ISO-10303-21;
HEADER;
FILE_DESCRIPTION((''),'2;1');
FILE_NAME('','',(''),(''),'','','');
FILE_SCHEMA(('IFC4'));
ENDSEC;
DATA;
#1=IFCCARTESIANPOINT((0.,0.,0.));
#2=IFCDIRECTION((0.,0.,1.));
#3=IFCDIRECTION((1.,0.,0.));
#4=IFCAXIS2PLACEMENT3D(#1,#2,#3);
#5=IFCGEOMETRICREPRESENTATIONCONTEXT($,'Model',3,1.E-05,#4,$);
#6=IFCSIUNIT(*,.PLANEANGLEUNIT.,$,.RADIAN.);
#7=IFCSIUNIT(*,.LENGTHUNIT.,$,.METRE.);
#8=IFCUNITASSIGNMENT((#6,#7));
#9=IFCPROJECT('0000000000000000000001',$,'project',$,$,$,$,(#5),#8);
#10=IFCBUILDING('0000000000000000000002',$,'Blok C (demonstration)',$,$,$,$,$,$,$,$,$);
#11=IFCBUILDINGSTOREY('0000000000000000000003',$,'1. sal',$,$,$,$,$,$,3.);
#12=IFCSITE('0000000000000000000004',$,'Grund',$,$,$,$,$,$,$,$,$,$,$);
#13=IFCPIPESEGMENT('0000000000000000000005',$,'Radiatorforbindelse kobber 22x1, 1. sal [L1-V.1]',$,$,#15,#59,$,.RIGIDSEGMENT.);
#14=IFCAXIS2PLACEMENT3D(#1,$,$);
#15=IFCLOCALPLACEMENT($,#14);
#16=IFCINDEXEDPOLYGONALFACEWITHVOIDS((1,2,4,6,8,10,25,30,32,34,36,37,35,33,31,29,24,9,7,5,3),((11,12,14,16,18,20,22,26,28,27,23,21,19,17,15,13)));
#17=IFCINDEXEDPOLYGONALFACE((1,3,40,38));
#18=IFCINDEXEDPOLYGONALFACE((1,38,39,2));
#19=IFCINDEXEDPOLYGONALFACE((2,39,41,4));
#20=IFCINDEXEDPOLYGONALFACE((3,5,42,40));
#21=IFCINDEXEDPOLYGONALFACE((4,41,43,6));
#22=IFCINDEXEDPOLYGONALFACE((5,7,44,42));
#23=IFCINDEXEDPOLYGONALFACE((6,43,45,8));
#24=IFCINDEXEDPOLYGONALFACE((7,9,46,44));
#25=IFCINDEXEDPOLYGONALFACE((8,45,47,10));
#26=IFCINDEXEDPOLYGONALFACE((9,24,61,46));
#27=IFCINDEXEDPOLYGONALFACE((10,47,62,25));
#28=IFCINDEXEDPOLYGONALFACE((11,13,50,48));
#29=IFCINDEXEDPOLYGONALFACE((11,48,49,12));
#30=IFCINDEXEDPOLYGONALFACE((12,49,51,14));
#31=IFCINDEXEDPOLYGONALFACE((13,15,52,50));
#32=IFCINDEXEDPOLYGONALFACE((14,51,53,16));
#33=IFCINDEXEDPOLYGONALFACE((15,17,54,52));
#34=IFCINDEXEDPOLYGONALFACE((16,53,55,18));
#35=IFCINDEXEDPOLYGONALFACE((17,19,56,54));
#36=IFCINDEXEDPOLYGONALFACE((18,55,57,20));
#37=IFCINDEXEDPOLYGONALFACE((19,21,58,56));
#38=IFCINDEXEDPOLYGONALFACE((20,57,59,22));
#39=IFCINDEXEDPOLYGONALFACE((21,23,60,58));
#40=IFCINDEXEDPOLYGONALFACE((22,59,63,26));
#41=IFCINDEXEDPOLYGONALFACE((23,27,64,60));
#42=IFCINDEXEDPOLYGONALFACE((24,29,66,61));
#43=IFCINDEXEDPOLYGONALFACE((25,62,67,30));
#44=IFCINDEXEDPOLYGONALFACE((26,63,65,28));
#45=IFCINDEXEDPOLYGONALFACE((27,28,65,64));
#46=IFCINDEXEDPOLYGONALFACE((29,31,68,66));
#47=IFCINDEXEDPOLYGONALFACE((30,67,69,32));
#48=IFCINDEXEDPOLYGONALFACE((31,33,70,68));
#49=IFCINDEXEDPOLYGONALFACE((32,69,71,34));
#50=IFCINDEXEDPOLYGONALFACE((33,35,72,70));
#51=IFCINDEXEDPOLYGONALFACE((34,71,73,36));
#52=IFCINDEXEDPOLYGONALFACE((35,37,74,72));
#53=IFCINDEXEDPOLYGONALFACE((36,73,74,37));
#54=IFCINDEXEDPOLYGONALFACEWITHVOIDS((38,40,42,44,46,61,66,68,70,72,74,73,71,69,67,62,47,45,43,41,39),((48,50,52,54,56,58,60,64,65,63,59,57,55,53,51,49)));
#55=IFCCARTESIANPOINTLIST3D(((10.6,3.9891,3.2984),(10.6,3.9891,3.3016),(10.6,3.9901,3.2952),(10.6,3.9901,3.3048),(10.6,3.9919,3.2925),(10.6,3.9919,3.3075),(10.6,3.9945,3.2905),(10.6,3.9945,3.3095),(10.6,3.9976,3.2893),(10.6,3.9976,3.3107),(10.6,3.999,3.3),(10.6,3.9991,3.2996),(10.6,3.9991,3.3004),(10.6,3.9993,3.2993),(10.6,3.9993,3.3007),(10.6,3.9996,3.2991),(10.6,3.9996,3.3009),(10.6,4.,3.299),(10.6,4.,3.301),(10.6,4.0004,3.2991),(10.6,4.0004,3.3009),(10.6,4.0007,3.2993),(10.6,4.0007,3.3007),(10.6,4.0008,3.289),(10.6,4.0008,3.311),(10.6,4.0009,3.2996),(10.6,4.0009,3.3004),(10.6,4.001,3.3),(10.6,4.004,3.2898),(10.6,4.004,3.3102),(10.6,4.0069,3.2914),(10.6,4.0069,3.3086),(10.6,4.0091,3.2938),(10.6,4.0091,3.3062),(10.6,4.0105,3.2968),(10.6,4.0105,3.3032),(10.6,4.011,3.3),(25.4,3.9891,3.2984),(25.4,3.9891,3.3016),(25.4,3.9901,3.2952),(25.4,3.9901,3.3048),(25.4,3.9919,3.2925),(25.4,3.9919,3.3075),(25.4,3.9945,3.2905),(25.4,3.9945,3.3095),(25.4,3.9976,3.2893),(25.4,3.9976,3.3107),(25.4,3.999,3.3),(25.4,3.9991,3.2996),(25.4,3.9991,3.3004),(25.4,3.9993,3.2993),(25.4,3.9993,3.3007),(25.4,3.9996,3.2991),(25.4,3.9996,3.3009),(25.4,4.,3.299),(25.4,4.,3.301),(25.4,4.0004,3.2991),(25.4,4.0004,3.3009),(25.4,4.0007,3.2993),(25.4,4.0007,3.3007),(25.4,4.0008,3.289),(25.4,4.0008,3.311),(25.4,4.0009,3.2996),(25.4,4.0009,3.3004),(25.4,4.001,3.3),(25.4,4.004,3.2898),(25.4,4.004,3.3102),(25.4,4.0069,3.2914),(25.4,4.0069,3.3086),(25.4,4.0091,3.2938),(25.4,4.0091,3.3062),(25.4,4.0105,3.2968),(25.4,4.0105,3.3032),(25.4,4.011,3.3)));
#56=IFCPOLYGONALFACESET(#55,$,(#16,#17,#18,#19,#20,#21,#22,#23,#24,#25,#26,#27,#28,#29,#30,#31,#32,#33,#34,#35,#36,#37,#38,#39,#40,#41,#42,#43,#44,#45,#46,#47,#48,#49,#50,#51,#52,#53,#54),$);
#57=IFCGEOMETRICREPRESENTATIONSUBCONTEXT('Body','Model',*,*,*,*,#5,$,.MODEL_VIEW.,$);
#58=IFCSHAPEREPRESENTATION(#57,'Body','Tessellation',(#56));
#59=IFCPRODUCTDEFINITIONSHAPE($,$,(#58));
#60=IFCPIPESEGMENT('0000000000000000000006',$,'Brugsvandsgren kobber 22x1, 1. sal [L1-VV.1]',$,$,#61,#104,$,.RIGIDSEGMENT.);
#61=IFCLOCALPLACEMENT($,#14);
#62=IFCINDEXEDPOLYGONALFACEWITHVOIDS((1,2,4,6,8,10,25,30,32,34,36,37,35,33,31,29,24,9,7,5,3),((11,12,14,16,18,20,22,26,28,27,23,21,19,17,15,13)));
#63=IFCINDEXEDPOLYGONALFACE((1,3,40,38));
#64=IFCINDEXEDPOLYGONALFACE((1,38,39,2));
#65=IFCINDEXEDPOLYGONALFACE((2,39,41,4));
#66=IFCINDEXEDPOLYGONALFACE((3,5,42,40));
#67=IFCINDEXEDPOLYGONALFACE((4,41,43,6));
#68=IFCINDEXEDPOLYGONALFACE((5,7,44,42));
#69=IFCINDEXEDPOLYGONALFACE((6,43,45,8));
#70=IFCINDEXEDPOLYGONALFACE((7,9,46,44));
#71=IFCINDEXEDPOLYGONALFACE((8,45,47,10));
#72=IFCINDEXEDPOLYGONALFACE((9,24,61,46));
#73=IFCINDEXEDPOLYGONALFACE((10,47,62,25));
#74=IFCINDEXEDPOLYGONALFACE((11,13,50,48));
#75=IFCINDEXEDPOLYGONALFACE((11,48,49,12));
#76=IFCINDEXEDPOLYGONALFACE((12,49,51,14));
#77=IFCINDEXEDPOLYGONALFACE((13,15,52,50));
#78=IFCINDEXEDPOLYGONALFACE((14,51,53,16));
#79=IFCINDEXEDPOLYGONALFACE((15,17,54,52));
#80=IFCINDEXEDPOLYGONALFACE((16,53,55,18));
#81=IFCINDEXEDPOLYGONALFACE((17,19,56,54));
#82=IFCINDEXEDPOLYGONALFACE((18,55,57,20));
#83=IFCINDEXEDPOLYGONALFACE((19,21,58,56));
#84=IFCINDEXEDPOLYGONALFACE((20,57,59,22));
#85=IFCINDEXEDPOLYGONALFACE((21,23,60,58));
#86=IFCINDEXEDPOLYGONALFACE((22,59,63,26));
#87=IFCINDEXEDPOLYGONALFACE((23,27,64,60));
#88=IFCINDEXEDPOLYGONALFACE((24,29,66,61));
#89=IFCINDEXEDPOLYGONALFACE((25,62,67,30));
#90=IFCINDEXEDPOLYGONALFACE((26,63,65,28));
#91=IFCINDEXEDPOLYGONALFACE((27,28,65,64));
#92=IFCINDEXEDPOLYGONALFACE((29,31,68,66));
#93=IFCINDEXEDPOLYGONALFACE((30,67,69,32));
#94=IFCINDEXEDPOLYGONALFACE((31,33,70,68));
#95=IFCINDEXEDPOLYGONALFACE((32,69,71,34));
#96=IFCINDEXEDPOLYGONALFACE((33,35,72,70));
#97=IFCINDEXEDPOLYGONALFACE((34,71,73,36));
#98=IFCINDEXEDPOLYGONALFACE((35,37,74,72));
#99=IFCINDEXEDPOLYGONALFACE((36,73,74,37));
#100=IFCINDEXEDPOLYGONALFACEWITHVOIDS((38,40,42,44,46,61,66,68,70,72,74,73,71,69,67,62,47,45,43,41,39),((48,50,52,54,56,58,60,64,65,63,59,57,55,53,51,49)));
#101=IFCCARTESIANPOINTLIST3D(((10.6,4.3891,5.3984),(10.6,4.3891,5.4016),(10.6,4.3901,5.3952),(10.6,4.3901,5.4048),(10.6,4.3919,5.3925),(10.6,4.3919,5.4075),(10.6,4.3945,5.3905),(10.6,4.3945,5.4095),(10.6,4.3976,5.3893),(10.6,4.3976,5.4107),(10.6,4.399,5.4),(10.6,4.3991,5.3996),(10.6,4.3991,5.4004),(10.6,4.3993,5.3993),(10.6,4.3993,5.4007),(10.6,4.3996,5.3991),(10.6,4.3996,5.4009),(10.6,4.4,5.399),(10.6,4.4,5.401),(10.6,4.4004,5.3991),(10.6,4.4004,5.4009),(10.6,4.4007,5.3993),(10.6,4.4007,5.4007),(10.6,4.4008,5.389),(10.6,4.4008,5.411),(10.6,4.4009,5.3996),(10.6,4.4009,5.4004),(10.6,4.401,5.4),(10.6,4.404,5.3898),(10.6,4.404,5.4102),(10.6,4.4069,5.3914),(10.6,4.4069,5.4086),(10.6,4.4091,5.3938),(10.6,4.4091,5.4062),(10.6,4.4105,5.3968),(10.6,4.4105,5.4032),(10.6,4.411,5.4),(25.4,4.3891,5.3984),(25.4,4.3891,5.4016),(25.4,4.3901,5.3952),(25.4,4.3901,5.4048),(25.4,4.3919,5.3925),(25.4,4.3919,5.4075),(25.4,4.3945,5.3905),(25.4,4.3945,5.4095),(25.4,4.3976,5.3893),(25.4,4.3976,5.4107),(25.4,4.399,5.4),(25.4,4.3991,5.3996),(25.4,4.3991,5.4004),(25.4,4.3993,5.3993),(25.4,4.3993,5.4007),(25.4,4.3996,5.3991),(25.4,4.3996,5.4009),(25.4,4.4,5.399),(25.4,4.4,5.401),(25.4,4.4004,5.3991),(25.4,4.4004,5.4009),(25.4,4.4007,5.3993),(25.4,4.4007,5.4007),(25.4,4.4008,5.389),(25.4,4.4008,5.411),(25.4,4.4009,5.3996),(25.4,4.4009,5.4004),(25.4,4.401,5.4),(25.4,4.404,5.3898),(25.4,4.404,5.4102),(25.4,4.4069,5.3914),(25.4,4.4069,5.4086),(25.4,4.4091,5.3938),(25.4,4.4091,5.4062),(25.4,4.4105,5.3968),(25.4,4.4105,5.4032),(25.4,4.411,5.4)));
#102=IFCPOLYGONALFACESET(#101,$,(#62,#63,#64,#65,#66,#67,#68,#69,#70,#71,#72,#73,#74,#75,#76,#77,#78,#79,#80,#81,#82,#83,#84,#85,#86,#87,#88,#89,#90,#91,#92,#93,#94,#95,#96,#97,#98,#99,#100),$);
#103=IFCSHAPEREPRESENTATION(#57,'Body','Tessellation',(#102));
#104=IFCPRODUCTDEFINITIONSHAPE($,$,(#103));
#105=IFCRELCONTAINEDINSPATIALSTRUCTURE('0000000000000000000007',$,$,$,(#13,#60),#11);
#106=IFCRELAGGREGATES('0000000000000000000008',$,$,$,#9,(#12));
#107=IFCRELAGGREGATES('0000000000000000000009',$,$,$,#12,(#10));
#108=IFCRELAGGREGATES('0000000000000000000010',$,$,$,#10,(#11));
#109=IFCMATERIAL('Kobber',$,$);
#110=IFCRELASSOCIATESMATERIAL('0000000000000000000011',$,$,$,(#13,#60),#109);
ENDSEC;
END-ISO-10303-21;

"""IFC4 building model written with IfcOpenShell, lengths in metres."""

from ifc_helpers import new_model, si_unit, frame, origin_with_axes, place, context, subcontext, project, spatial, hollow_circle, extrude, material, element, save


model = new_model("IFC4")

# Units and contexts
model_context = context("Model", 3, precision=1e-05, world=origin_with_axes())
body_context = subcontext(model_context, "Body", "Model", "MODEL_VIEW")
ifc_project = project(units=[si_unit("PLANEANGLEUNIT", "RADIAN"), si_unit("LENGTHUNIT", "METRE")], contexts=[model_context])

# Site, building, storey
site = spatial("IfcSite", under=ifc_project, Name="Grund")
building = spatial("IfcBuilding", under=site, Name="Blok C (demonstration)")
storey = spatial("IfcBuildingStorey", under=building, Name="1. sal", Elevation=3.0)

# Pipe segments
ifc_material_1 = material(Name="Kobber")
pipe_segment_1_placement = place(None, origin_with_axes())
element("IfcPipeSegment", 1, at=pipe_segment_1_placement, inside=storey, material=ifc_material_1, Name="Radiatorforbindelse kobber 22x1, 1. sal [L1-V.1]", PredefinedType="RIGIDSEGMENT", context=body_context, shape_type="SweptSolid", body=[
    extrude(hollow_circle(Radius=0.011, WallThickness=0.01), frame((10.6, 4.0, 3.3), z_axis=(1.0, 0.0, 0.0), x_axis=(0.0, 1.0, 0.0)), (0.0, 0.0, 1.0), 14.8),
])
pipe_segment_2_placement = place(None, origin_with_axes())
element("IfcPipeSegment", 2, at=pipe_segment_2_placement, inside=storey, material=ifc_material_1, Name="Brugsvandsgren kobber 22x1, 1. sal [L1-VV.1]", PredefinedType="RIGIDSEGMENT", context=body_context, shape_type="SweptSolid", body=[
    extrude(hollow_circle(Radius=0.011, WallThickness=0.01), frame((10.6, 4.4, 5.4), z_axis=(1.0, 0.0, 0.0), x_axis=(0.0, 1.0, 0.0)), (0.0, 0.0, 1.0), 14.8),
])

save(model, "model.ifc")
